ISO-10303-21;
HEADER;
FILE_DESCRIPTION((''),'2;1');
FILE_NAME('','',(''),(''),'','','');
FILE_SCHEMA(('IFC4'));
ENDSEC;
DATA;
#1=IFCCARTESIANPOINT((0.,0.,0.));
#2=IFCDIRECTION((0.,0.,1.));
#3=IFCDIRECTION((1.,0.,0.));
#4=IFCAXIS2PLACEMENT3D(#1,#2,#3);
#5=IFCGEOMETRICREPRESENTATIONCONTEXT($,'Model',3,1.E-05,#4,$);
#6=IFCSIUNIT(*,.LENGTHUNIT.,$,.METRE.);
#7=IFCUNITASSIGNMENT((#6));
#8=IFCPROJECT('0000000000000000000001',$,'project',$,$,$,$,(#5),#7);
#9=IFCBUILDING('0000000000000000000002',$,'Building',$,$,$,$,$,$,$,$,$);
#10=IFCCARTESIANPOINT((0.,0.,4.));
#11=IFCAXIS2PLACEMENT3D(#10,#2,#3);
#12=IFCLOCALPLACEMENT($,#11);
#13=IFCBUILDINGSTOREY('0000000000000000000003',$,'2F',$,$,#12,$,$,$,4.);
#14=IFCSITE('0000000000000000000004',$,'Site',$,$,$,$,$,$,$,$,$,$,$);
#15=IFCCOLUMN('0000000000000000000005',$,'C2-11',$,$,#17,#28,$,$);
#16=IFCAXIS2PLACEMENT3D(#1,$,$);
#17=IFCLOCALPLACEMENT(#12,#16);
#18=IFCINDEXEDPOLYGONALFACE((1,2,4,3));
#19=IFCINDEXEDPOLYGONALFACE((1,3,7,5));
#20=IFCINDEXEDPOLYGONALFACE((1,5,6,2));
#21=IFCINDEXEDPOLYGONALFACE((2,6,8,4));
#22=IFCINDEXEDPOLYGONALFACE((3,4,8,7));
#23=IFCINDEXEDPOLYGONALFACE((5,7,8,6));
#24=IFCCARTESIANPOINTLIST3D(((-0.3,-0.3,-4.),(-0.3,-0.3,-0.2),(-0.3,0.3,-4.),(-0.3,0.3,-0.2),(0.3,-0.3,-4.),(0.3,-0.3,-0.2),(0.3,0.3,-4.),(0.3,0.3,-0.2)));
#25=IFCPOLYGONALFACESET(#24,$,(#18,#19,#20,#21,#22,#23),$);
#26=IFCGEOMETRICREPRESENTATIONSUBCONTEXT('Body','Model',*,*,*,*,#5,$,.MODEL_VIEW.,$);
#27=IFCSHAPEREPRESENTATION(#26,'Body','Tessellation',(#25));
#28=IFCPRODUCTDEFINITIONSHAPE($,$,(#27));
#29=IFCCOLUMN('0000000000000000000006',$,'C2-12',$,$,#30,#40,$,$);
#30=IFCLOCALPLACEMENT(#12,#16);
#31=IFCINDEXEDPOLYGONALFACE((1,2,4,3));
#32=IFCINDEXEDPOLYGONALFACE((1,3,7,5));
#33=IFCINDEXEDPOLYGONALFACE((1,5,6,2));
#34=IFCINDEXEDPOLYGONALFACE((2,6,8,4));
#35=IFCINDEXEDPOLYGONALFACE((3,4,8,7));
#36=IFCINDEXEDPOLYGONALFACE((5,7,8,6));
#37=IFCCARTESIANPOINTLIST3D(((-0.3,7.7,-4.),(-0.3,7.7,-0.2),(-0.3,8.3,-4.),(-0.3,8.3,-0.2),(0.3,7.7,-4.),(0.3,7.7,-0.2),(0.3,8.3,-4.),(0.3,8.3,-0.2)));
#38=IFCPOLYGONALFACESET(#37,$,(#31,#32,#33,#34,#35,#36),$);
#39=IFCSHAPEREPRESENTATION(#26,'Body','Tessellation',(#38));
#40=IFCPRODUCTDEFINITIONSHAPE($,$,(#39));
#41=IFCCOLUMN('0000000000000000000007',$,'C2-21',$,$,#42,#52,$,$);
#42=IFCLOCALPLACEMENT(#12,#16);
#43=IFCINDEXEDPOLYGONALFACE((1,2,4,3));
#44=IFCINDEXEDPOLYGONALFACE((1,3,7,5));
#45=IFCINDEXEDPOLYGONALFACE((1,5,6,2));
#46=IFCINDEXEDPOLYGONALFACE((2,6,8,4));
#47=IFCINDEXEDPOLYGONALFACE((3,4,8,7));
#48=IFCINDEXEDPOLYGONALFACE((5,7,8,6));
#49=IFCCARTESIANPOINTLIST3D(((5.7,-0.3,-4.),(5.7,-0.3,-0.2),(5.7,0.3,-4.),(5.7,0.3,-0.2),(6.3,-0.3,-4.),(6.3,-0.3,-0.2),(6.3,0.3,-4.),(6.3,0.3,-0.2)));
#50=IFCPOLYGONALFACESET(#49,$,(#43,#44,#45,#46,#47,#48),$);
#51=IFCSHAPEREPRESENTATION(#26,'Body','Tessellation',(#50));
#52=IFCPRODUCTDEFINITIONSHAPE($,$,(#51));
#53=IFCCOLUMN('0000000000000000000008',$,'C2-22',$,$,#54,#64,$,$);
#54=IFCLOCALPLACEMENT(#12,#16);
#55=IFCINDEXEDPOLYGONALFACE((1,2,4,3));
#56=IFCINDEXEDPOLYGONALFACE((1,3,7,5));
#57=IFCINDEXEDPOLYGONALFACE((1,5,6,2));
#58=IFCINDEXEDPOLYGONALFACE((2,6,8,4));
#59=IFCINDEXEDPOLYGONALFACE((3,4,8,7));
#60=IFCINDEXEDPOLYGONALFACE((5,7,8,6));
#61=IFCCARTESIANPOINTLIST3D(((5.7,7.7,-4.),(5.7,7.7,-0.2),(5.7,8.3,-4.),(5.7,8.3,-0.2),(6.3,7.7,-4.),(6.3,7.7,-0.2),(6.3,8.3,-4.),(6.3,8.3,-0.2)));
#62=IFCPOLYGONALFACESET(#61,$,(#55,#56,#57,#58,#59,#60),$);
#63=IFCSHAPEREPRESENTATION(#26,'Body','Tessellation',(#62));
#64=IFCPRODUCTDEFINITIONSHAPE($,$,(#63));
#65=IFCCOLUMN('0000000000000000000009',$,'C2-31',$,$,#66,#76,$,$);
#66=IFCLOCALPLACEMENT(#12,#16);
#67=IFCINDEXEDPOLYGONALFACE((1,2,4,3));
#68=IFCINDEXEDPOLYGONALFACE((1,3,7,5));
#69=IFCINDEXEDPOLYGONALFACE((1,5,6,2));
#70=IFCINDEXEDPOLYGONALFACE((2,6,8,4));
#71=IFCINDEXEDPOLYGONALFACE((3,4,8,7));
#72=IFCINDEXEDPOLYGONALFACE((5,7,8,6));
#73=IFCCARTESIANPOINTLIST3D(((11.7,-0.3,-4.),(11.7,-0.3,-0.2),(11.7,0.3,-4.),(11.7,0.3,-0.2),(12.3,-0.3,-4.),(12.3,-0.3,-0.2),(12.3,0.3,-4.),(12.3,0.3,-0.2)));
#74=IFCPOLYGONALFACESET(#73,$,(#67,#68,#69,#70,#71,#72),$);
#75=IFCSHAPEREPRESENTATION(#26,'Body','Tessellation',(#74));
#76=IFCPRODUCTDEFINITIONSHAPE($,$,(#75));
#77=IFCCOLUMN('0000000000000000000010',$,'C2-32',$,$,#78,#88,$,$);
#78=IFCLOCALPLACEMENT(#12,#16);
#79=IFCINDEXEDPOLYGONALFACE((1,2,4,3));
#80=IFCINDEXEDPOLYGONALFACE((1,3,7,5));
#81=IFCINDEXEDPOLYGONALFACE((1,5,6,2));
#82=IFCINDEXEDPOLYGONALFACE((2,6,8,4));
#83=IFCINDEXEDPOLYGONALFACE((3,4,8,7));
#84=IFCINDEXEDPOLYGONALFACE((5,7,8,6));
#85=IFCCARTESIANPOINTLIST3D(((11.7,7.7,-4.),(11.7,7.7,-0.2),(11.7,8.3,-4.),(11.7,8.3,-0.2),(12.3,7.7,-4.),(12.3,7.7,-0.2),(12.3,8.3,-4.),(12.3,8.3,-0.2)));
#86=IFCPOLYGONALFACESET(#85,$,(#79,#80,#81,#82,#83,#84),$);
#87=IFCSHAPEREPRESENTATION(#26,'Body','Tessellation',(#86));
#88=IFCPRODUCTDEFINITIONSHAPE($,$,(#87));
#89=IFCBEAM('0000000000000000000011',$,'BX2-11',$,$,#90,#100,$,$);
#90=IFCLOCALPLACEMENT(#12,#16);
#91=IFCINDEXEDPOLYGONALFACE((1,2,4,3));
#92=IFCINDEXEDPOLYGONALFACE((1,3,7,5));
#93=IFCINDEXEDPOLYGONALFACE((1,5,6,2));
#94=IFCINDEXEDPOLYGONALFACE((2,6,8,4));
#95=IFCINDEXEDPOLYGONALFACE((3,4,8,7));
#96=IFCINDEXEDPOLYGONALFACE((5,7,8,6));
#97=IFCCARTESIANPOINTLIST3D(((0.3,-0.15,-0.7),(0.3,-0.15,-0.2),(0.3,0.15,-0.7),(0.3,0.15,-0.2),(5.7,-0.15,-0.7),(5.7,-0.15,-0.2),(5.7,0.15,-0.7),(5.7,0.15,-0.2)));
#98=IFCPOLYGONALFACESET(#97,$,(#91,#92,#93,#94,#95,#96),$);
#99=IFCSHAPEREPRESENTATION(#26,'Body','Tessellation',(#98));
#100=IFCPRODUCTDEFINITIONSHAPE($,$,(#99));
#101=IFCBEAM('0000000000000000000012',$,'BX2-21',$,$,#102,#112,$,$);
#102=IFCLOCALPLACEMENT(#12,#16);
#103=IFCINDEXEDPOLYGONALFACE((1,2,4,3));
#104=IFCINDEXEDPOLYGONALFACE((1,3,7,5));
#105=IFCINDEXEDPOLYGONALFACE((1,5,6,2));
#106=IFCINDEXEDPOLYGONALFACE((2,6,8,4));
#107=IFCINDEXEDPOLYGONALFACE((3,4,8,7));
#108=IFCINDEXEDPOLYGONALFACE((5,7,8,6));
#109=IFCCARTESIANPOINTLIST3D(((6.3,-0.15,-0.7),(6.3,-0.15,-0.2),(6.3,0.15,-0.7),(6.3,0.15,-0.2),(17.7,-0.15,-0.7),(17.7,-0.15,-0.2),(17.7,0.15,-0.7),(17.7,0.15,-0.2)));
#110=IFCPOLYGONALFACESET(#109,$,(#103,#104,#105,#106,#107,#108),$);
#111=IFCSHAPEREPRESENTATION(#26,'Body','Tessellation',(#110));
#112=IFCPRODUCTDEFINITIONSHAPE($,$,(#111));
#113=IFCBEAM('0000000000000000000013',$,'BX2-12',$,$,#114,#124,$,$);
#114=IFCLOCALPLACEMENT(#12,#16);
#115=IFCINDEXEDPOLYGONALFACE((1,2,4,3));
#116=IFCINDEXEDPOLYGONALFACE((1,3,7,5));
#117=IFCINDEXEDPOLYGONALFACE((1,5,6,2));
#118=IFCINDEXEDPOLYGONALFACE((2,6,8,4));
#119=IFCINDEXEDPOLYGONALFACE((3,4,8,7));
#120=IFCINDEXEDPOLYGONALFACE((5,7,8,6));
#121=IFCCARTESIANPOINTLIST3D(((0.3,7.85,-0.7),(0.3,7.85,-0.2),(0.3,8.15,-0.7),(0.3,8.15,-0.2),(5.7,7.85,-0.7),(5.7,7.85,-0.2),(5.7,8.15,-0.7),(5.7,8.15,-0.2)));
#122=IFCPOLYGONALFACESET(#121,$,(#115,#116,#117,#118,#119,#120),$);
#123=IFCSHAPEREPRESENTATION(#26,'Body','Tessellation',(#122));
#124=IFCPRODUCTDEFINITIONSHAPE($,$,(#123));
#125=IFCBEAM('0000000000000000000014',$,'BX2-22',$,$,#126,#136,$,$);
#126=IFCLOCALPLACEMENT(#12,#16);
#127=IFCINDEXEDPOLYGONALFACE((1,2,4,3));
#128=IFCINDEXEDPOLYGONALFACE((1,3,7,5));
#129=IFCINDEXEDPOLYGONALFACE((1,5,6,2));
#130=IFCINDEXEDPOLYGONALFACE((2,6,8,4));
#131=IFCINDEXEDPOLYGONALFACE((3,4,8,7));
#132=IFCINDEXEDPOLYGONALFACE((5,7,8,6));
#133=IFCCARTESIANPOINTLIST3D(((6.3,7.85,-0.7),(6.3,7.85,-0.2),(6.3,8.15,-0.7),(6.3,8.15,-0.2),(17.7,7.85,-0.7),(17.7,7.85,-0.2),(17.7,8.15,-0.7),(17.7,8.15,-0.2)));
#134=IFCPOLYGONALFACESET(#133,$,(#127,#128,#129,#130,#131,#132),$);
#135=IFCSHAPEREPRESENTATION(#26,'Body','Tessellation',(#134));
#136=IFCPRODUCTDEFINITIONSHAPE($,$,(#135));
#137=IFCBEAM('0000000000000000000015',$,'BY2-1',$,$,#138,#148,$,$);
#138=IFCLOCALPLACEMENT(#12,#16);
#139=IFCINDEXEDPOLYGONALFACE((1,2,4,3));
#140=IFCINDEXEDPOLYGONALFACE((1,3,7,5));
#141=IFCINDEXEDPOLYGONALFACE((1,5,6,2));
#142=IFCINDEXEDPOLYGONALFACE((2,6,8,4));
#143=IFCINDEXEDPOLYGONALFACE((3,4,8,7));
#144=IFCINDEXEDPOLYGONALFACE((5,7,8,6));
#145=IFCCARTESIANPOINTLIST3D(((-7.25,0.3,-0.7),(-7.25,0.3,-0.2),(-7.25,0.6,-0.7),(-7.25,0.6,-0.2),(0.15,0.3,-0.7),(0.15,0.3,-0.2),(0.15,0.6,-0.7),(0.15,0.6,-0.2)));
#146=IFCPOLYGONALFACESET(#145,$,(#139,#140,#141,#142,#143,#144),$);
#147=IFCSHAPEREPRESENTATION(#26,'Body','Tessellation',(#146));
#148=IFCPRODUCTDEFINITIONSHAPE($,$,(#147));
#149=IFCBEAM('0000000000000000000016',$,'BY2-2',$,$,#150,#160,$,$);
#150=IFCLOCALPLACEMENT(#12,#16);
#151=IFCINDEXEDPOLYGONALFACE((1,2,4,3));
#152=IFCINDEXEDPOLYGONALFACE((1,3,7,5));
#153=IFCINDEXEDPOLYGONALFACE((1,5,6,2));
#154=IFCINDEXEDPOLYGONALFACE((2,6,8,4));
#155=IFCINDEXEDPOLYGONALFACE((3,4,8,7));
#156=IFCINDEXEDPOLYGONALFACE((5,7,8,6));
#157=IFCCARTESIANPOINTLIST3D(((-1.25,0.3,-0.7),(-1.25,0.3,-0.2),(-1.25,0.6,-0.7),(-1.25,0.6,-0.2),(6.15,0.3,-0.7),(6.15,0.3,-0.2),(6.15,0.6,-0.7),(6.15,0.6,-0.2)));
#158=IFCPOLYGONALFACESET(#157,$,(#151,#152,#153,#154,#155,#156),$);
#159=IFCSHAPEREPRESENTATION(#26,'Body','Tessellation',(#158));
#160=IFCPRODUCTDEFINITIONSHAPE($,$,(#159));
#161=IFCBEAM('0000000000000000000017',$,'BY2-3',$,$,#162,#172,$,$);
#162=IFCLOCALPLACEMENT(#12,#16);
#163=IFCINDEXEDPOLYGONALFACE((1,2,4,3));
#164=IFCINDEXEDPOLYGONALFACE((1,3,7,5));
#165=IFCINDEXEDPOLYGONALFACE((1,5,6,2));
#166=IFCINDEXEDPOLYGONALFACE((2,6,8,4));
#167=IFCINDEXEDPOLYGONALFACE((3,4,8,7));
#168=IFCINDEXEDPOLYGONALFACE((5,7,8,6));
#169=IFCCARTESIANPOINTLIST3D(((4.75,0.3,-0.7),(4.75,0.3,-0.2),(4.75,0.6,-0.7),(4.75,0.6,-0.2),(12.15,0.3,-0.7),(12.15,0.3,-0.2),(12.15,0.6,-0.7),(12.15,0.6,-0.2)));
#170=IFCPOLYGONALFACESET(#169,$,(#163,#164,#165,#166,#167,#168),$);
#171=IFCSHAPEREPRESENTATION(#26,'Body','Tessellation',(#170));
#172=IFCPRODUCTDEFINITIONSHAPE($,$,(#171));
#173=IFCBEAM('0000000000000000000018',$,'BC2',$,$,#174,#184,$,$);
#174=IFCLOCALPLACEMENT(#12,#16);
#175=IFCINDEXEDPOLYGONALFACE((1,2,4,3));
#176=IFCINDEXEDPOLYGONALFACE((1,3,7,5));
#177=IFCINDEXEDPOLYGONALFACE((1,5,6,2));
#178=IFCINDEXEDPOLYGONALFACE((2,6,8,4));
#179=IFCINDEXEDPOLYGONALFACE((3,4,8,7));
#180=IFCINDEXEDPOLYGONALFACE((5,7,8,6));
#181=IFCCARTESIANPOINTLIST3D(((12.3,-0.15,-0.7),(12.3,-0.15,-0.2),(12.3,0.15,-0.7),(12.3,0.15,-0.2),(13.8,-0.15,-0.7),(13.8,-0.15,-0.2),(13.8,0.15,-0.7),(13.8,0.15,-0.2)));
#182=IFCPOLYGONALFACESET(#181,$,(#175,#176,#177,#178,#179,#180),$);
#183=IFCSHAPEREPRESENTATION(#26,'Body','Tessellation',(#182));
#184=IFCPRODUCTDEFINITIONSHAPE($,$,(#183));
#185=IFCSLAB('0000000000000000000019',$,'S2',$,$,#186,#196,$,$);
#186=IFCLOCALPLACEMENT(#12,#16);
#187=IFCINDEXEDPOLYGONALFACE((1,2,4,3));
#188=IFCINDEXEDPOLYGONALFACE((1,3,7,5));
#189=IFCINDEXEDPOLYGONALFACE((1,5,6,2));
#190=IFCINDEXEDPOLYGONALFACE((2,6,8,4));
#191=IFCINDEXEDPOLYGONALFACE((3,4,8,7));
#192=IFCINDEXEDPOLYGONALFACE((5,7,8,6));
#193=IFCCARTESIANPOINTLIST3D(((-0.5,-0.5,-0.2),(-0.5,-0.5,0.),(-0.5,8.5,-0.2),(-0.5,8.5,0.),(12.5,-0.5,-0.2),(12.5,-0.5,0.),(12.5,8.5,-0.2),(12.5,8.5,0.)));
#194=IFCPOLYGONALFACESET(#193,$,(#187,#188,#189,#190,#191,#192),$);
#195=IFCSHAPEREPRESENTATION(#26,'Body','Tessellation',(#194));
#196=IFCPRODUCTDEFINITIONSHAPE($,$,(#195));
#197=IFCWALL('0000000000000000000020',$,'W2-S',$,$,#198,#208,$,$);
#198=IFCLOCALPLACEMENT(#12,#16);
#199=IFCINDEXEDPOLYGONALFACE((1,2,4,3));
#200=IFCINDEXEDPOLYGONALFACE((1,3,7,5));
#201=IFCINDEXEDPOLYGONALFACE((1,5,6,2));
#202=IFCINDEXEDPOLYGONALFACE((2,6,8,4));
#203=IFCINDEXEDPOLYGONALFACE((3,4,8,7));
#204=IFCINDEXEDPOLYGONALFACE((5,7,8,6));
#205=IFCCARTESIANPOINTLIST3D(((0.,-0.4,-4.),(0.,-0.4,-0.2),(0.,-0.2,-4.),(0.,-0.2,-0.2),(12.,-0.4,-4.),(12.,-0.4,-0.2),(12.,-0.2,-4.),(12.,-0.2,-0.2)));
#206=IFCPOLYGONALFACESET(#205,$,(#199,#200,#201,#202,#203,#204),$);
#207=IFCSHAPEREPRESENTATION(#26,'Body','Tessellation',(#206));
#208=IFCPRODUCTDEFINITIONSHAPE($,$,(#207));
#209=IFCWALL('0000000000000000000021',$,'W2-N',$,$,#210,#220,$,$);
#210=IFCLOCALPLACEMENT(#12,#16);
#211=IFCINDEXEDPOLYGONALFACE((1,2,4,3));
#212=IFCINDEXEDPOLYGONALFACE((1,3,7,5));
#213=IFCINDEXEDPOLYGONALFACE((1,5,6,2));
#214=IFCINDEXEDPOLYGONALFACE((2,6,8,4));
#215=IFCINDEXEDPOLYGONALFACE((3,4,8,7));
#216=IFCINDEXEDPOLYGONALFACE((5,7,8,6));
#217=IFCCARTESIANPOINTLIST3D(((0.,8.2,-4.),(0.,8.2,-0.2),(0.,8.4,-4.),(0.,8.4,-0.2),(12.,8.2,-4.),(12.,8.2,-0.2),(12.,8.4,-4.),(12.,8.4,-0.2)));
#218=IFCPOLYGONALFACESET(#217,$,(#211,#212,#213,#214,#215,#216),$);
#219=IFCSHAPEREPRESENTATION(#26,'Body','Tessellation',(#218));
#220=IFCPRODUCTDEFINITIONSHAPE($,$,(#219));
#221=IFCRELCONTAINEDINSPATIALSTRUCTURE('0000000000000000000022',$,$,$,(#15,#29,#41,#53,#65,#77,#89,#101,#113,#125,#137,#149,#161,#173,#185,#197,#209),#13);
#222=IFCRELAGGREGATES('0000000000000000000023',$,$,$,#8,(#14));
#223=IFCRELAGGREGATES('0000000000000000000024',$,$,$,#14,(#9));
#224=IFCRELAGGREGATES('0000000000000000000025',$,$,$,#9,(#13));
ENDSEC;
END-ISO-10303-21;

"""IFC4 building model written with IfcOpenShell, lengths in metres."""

from ifc_helpers import new_model, si_unit, frame, origin_with_axes, place, context, subcontext, project, spatial, indexed_curve, outline, extrude, shape, element, save


model = new_model("IFC4")

# Units and contexts
model_context = context("Model", 3, precision=1e-05, world=origin_with_axes())
body_context = subcontext(model_context, "Body", "Model", "MODEL_VIEW")
ifc_project = project(units=[si_unit("LENGTHUNIT", "METRE")], contexts=[model_context])

# Site, building, storey
site = spatial("IfcSite", under=ifc_project, Name="Site")
building = spatial("IfcBuilding", under=site, Name="Building")
storey_placement = place(None, frame((0.0, 0.0, 4.0), z_axis=(0.0, 0.0, 1.0), x_axis=(1.0, 0.0, 0.0)))
storey = spatial("IfcBuildingStorey", under=building, at=storey_placement, Name="2F", Elevation=4.0)

# Columns
for number, where, z_axis, x_axis, name in (
    (1, (-0.3, -0.3, -4.0), (0.0, 0.0, 1.0), (1.0, 0.0, 0.0), "C2-11"),
    (2, (-0.3, 7.7, -4.0), (0.0, 0.0, 1.0), (1.0, 0.0, 0.0), "C2-12"),
    (3, (5.7, -0.3, -4.0), (0.0, 0.0, 1.0), (1.0, 0.0, 0.0), "C2-21"),
    (4, (5.7, 7.7, -4.0), (0.0, 0.0, 1.0), (1.0, 0.0, 0.0), "C2-22"),
    (5, (11.7, -0.3, -4.0), (0.0, 0.0, 1.0), (1.0, 0.0, 0.0), "C2-31"),
    (6, (11.7, 7.7, -4.0), (0.0, 0.0, 1.0), (1.0, 0.0, 0.0), "C2-32"),
):
    element("IfcColumn", number, at=place(storey_placement, frame(where, z_axis=z_axis, x_axis=x_axis)), inside=storey, Name=name, context=body_context, shape_type="SweptSolid", body=[
        extrude(outline(indexed_curve([(0.0, 0.0), (0.0, 0.6), (0.6, 0.6), (0.6, 0.0), (0.0, 0.0)], self_intersect=False)), origin_with_axes(), (0.0, 0.0, 1.0), 3.8),
    ])

# Beams
beam_1_placement = place(storey_placement, frame((0.3, -0.15, -0.7), z_axis=(0.0, 0.0, 1.0), x_axis=(1.0, 0.0, 0.0)))
element("IfcBeam", 7, at=beam_1_placement, inside=storey, Name="BX2-11", context=body_context, shape_type="SweptSolid", body=[
    extrude(outline(indexed_curve([(0.0, 0.0), (0.0, 0.3), (5.4, 0.3), (5.4, 0.0), (0.0, 0.0)], self_intersect=False)), origin_with_axes(), (0.0, 0.0, 1.0), 0.5),
])
beam_2_placement = place(storey_placement, frame((6.3, -0.15, -0.7), z_axis=(0.0, 0.0, 1.0), x_axis=(1.0, 0.0, 0.0)))
element("IfcBeam", 8, at=beam_2_placement, inside=storey, Name="BX2-21", context=body_context, shape_type="SweptSolid", body=[
    extrude(outline(indexed_curve([(0.0, 0.0), (0.0, 0.3), (11.4, 0.3), (11.4, 0.0), (0.0, 0.0)], self_intersect=False)), origin_with_axes(), (0.0, 0.0, 1.0), 0.5),
])
beam_3_placement = place(storey_placement, frame((0.3, 7.85, -0.7), z_axis=(0.0, 0.0, 1.0), x_axis=(1.0, 0.0, 0.0)))
element("IfcBeam", 9, at=beam_3_placement, inside=storey, Name="BX2-12", context=body_context, shape_type="SweptSolid", body=[
    extrude(outline(indexed_curve([(0.0, 0.0), (0.0, 0.3), (5.4, 0.3), (5.4, 0.0), (0.0, 0.0)], self_intersect=False)), origin_with_axes(), (0.0, 0.0, 1.0), 0.5),
])
beam_4_placement = place(storey_placement, frame((6.3, 7.85, -0.7), z_axis=(0.0, 0.0, 1.0), x_axis=(1.0, 0.0, 0.0)))
element("IfcBeam", 10, at=beam_4_placement, inside=storey, Name="BX2-22", context=body_context, shape_type="SweptSolid", body=[
    extrude(outline(indexed_curve([(0.0, 0.0), (0.0, 0.3), (11.4, 0.3), (11.4, 0.0), (0.0, 0.0)], self_intersect=False)), origin_with_axes(), (0.0, 0.0, 1.0), 0.5),
])
for number, where, z_axis, x_axis, name in (
    (11, (0.15, 0.3, -0.7), (0.0, 0.0, 1.0), (0.0, 1.0, 0.0), "BY2-1"),
    (12, (6.15, 0.3, -0.7), (0.0, 0.0, 1.0), (0.0, 1.0, 0.0), "BY2-2"),
    (13, (12.15, 0.3, -0.7), (0.0, 0.0, 1.0), (0.0, 1.0, 0.0), "BY2-3"),
):
    element("IfcBeam", number, at=place(storey_placement, frame(where, z_axis=z_axis, x_axis=x_axis)), inside=storey, Name=name, shapes=[
        shape(body_context, "Body", "SweptSolid", [extrude(outline(indexed_curve([(0.0, 0.0), (0.0, 7.4), (0.3, 7.4), (0.3, 0.0), (0.0, 0.0)], self_intersect=False)), origin_with_axes(), (0.0, 0.0, 1.0), 0.5)]),
        shape(body_context, "Body", "SweptSolid", [extrude(outline(indexed_curve([(0.0, 0.0), (0.0, 0.3), (7.4, 0.3), (7.4, 0.0), (0.0, 0.0)], self_intersect=False)), origin_with_axes(), (0.0, 0.0, 1.0), 0.5)]),
    ])
beam_5_placement = place(storey_placement, frame((12.3, -0.15, -0.7), z_axis=(0.0, 0.0, 1.0), x_axis=(1.0, 0.0, 0.0)))
element("IfcBeam", 14, at=beam_5_placement, inside=storey, Name="BC2", context=body_context, shape_type="SweptSolid", body=[
    extrude(outline(indexed_curve([(0.0, 0.0), (0.0, 0.3), (1.5, 0.3), (1.5, 0.0), (0.0, 0.0)], self_intersect=False)), origin_with_axes(), (0.0, 0.0, 1.0), 0.5),
])

# Slab
slab_placement = place(storey_placement, frame((-0.5, -0.5, -0.2), z_axis=(0.0, 0.0, 1.0), x_axis=(1.0, 0.0, 0.0)))
element("IfcSlab", 15, at=slab_placement, inside=storey, Name="S2", context=body_context, shape_type="SweptSolid", body=[
    extrude(outline(indexed_curve([(0.0, 0.0), (0.0, 9.0), (13.0, 9.0), (13.0, 0.0), (0.0, 0.0)], self_intersect=False)), origin_with_axes(), (0.0, 0.0, 1.0), 0.2),
])

# Walls
for number, where, z_axis, x_axis, name in (
    (16, (0.0, -0.4, -4.0), (0.0, 0.0, 1.0), (1.0, 0.0, 0.0), "W2-S"),
    (17, (0.0, 8.2, -4.0), (0.0, 0.0, 1.0), (1.0, 0.0, 0.0), "W2-N"),
):
    element("IfcWall", number, at=place(storey_placement, frame(where, z_axis=z_axis, x_axis=x_axis)), inside=storey, Name=name, context=body_context, shape_type="SweptSolid", body=[
        extrude(outline(indexed_curve([(0.0, 0.0), (0.0, 0.2), (12.0, 0.2), (12.0, 0.0), (0.0, 0.0)], self_intersect=False)), origin_with_axes(), (0.0, 0.0, 1.0), 3.8),
    ])

save(model, "model.ifc")
